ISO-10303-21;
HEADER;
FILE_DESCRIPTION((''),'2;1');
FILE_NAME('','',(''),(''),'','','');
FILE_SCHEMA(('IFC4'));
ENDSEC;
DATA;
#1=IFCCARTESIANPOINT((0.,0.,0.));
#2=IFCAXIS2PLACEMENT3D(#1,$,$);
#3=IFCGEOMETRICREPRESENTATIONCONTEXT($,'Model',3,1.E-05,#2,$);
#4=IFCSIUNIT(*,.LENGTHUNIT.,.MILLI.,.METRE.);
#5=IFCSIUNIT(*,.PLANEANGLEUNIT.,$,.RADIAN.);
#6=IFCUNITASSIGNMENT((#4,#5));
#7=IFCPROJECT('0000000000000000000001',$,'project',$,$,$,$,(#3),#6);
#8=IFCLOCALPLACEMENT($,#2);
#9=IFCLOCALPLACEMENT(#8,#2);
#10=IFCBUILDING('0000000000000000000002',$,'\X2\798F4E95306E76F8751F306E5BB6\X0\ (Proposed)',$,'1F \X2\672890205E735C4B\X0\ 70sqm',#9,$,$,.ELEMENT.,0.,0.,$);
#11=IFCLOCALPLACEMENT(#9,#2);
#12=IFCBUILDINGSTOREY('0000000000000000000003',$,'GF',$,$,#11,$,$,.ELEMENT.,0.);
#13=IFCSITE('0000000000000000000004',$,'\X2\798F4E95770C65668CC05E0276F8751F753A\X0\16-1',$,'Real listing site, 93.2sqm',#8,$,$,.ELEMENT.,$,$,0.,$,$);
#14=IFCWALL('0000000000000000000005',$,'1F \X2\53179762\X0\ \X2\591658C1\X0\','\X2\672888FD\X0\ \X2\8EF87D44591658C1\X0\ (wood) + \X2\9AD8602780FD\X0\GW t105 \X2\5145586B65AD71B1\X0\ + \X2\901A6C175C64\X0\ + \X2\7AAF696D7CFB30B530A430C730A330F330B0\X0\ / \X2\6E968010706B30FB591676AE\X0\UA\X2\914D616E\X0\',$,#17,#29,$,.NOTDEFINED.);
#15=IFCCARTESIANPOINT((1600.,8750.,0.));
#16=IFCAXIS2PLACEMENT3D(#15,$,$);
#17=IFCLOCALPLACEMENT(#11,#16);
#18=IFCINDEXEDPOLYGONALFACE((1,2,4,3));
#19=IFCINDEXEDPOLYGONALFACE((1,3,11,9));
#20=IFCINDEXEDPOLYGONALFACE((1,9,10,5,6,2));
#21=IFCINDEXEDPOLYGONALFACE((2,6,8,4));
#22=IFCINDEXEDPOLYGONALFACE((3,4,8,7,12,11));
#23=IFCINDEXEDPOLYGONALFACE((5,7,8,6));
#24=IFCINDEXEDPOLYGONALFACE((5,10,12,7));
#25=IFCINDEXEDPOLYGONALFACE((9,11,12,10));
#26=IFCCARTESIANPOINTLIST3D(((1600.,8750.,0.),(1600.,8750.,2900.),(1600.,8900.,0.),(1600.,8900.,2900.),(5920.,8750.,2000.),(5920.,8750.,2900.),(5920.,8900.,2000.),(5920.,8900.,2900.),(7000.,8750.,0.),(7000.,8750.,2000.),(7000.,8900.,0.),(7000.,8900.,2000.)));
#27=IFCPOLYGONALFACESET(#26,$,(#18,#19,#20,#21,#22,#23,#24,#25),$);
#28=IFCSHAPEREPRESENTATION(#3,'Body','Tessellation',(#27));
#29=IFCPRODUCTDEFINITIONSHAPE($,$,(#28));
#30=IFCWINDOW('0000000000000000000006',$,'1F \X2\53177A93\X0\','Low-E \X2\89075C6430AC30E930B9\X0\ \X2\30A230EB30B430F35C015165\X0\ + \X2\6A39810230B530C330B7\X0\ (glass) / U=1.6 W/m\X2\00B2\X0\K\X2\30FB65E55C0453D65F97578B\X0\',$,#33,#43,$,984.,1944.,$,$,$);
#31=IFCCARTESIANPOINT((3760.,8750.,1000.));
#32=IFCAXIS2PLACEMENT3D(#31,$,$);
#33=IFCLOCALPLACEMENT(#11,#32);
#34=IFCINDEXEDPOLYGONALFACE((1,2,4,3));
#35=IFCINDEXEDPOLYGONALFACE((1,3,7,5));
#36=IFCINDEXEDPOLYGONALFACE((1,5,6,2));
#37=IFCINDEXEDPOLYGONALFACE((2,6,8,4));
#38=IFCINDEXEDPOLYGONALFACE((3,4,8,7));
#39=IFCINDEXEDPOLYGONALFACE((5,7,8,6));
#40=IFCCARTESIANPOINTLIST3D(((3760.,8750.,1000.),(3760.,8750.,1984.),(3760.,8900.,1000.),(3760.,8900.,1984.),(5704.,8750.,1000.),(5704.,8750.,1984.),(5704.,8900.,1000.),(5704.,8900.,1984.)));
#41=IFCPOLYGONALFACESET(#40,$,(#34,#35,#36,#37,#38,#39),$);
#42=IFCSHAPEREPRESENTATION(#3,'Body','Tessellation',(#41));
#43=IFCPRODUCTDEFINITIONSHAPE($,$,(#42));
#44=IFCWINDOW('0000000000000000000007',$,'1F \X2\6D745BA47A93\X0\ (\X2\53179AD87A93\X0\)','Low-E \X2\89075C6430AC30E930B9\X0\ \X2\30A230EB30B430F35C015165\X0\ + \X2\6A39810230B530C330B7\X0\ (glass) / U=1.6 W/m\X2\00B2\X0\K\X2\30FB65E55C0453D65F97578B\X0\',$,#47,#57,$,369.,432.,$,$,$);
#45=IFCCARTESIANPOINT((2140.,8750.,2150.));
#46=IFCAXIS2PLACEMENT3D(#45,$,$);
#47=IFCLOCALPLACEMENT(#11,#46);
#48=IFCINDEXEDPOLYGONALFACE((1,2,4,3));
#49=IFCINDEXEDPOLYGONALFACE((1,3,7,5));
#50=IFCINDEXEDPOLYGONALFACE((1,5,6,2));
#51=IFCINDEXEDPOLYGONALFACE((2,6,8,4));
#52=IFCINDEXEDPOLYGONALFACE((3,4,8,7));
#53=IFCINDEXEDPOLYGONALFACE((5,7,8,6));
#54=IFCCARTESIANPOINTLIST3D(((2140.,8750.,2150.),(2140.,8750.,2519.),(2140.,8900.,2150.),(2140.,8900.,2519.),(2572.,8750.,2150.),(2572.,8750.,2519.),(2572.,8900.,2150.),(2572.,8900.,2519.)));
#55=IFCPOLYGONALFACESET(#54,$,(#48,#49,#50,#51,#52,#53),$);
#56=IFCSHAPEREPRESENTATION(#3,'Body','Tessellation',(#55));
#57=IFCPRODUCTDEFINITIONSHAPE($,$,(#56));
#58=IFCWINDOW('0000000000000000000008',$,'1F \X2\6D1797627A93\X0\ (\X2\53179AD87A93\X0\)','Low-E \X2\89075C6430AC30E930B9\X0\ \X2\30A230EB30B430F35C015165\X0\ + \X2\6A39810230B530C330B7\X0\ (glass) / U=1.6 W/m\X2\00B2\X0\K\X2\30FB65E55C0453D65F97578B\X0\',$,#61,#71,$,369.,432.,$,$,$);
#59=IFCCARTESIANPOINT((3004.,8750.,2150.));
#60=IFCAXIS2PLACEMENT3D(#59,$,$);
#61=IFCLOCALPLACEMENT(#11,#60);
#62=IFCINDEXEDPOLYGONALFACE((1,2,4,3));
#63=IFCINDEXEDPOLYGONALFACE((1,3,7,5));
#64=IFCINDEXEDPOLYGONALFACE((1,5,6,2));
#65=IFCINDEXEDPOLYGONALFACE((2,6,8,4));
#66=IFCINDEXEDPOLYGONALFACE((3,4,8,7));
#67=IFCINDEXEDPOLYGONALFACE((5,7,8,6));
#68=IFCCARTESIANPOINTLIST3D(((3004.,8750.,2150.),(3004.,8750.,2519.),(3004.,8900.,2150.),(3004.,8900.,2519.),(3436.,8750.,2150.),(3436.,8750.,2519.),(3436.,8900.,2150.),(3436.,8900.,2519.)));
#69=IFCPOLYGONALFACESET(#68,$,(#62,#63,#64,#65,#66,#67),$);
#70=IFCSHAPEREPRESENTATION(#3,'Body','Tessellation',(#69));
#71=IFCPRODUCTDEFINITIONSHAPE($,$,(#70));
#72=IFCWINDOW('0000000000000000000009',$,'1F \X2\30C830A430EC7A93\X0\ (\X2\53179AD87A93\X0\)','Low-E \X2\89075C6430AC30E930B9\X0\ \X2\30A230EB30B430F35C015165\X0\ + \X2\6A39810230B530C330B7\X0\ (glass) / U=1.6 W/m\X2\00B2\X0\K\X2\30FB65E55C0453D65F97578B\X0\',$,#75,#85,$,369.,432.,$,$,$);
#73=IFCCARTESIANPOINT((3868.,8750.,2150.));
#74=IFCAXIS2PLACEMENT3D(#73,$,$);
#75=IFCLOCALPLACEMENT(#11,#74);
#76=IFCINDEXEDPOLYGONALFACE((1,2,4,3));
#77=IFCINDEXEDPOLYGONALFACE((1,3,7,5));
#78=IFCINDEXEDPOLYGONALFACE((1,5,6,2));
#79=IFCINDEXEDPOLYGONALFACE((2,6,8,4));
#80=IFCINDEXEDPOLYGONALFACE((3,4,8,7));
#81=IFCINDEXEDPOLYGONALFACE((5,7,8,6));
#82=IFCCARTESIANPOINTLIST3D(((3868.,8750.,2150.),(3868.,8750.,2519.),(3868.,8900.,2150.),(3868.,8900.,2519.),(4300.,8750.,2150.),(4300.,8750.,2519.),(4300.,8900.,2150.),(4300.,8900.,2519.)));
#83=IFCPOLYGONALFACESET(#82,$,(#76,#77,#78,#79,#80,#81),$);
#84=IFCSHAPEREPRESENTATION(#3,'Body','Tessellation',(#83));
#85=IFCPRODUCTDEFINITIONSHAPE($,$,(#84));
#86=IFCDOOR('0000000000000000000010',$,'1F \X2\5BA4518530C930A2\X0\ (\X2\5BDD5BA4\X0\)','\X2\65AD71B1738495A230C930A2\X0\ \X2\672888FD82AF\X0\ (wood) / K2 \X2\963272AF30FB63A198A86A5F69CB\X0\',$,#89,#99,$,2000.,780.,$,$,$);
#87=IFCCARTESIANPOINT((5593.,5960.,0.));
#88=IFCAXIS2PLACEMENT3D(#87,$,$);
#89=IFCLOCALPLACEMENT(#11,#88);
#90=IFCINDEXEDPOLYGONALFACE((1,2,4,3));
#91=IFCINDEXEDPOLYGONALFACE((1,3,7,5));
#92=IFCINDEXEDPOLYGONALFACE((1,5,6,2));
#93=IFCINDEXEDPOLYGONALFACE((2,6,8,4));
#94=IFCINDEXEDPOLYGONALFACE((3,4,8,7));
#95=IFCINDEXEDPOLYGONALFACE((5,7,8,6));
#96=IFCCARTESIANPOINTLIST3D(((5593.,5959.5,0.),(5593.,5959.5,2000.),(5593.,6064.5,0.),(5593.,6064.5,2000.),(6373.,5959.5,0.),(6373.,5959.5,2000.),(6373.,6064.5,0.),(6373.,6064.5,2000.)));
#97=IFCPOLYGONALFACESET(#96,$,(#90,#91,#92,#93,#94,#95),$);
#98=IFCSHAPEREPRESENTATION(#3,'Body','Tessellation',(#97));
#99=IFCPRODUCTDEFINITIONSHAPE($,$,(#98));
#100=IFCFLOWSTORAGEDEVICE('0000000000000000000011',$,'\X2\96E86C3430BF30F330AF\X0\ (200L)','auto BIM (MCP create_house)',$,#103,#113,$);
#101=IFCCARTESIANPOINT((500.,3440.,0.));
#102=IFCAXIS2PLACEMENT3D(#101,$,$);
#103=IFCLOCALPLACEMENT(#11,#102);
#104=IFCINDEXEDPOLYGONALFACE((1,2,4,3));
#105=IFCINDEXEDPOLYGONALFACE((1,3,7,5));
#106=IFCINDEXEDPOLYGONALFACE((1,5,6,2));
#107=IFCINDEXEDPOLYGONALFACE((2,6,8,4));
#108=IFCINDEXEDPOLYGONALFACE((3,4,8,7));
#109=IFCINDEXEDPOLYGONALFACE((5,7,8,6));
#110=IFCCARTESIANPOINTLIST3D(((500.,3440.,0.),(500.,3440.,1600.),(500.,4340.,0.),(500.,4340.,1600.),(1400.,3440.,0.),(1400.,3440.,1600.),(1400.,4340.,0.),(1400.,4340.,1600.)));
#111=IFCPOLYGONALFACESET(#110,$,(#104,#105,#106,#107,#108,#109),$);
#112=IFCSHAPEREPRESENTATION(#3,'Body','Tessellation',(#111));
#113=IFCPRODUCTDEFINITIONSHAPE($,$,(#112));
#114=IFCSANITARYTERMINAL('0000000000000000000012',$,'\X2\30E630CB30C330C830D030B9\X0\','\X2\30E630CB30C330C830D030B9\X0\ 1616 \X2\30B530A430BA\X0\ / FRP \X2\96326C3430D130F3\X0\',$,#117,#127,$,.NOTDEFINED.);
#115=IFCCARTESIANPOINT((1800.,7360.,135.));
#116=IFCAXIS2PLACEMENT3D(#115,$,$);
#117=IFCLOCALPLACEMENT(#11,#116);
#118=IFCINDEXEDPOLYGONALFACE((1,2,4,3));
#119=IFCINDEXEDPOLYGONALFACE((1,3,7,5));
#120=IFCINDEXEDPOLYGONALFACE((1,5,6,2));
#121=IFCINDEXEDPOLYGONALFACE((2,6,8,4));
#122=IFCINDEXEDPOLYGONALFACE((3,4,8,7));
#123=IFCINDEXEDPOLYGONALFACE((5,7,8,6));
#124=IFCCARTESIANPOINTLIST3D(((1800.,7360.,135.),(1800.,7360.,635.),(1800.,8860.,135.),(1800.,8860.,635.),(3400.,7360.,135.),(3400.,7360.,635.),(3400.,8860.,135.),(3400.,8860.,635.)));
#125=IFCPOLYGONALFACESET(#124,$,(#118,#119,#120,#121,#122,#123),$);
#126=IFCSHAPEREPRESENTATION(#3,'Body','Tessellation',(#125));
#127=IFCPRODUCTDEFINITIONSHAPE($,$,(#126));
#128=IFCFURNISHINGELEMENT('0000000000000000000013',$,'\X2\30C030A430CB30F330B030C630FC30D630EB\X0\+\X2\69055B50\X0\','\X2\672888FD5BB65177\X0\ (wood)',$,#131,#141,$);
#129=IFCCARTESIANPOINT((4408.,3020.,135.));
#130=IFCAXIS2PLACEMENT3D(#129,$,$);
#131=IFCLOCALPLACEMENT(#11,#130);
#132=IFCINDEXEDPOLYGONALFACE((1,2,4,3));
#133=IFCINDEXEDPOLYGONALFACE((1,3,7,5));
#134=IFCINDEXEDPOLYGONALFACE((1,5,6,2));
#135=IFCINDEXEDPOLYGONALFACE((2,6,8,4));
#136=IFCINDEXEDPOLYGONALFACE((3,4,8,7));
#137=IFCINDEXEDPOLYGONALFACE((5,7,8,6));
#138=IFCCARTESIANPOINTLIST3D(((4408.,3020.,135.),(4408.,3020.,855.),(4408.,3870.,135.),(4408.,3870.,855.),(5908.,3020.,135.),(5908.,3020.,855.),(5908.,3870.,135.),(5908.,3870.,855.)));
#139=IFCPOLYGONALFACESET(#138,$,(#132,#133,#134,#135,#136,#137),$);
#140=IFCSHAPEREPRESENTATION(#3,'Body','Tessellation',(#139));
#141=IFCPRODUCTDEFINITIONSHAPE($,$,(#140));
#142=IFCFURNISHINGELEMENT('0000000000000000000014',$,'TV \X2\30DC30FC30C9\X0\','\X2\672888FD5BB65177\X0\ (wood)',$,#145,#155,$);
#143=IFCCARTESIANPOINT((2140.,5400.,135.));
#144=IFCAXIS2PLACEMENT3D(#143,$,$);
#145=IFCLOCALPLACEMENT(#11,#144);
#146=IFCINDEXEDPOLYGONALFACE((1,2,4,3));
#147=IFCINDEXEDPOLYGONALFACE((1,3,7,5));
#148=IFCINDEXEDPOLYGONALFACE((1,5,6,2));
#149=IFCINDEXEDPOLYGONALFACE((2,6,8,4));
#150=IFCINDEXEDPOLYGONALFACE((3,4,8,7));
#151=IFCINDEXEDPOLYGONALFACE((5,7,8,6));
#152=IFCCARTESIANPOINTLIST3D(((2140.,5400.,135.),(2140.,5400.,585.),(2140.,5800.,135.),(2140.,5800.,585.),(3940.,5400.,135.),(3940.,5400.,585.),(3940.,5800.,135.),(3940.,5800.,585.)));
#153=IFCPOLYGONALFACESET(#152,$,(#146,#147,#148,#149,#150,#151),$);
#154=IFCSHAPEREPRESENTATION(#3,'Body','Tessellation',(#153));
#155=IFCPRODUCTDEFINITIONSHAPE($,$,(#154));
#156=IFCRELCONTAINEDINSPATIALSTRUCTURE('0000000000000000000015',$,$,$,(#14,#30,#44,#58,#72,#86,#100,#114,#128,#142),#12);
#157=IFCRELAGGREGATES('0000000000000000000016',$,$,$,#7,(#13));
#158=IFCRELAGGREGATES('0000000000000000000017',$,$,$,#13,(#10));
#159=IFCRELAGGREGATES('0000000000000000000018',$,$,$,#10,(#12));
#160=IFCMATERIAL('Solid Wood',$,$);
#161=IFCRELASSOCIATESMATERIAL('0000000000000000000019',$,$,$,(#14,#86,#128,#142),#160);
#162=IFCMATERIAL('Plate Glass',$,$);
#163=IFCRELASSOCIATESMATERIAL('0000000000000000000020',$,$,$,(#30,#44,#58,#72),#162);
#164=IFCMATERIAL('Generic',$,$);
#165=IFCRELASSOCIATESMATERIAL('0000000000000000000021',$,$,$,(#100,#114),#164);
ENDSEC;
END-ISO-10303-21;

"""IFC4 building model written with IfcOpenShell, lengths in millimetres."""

from ifc_helpers import new_model, si_unit, frame, frame_2d, origin, place, context, project, spatial, rectangle, extrude, material, element, fill, save


model = new_model("IFC4")

# Units and contexts
model_context = context("Model", 3, precision=1e-05, world=origin())
ifc_project = project(units=[si_unit("LENGTHUNIT", "METRE", prefix="MILLI"), si_unit("PLANEANGLEUNIT", "RADIAN")], contexts=[model_context])

# Site, building, storey
site_placement = place(None, origin())
site = spatial("IfcSite", under=ifc_project, at=site_placement, Name="福井県敦賀市相生町16-1", ObjectType="Real listing site, 93.2sqm", CompositionType="ELEMENT", RefElevation=0.0)
building_placement = place(site_placement, origin())
building = spatial("IfcBuilding", under=site, at=building_placement, Name="福井の相生の家 (Proposed)", ObjectType="1F 木造平屋 70sqm", CompositionType="ELEMENT", ElevationOfRefHeight=0.0, ElevationOfTerrain=0.0)
storey_placement = place(building_placement, origin())
storey = spatial("IfcBuildingStorey", under=building, at=storey_placement, Name="GF", CompositionType="ELEMENT", Elevation=0.0)

# Wall, openings, windows
ifc_material_1 = material(Name="Solid Wood")
wall_1_placement = place(storey_placement, frame((1600.0, 8750.0, 0.0)))
wall_1 = element("IfcWall", 1, at=wall_1_placement, inside=storey, material=ifc_material_1, Name="1F 北面 外壁", Description="木製 軸組外壁 (wood) + 高性能GW t105 充填断熱 + 通気層 + 窯業系サイディング / 準耐火・外皮UA配慮", PredefinedType="NOTDEFINED", context=model_context, shape_type="SweptSolid", body=[
    extrude(rectangle(XDim=5400.0, YDim=150.0, at=frame_2d((2700.0, 75.0))), frame((1600.0, 8750.0, 0.0)), (0.0, 0.0, 1.0), 2900.0),
])
opening_1_placement = place(storey_placement, frame((3760.0, 8750.0, 1000.0)))
opening_1 = element("IfcOpeningElement", 2, at=opening_1_placement, cuts=wall_1, PredefinedType="NOTDEFINED", context=model_context, shape_type="SweptSolid", body=[
    extrude(rectangle(XDim=1944.0, YDim=150.0, at=frame_2d((972.0, 75.0))), frame((3760.0, 8750.0, 1000.0)), (0.0, 0.0, 1.0), 984.0),
])
opening_2_placement = place(storey_placement, frame((2140.0, 8750.0, 2150.0)))
opening_2 = element("IfcOpeningElement", 3, at=opening_2_placement, cuts=wall_1, PredefinedType="NOTDEFINED", context=model_context, shape_type="SweptSolid", body=[
    extrude(rectangle(XDim=432.0, YDim=150.0, at=frame_2d((216.0, 75.0))), frame((2140.0, 8750.0, 2150.0)), (0.0, 0.0, 1.0), 369.0),
])
opening_3_placement = place(storey_placement, frame((3004.0, 8750.0, 2150.0)))
opening_3 = element("IfcOpeningElement", 4, at=opening_3_placement, cuts=wall_1, PredefinedType="NOTDEFINED", context=model_context, shape_type="SweptSolid", body=[
    extrude(rectangle(XDim=432.0, YDim=150.0, at=frame_2d((216.0, 75.0))), frame((3004.0, 8750.0, 2150.0)), (0.0, 0.0, 1.0), 369.0),
])
opening_4_placement = place(storey_placement, frame((3868.0, 8750.0, 2150.0)))
opening_4 = element("IfcOpeningElement", 5, at=opening_4_placement, cuts=wall_1, PredefinedType="NOTDEFINED", context=model_context, shape_type="SweptSolid", body=[
    extrude(rectangle(XDim=432.0, YDim=150.0, at=frame_2d((216.0, 75.0))), frame((3868.0, 8750.0, 2150.0)), (0.0, 0.0, 1.0), 369.0),
])
ifc_material_2 = material(Name="Plate Glass")
window_1_placement = place(storey_placement, frame((3760.0, 8750.0, 1000.0)))
window_1 = element("IfcWindow", 6, at=window_1_placement, inside=storey, material=ifc_material_2, Name="1F 北窓", Description="Low-E 複層ガラス アルゴン封入 + 樹脂サッシ (glass) / U=1.6 W/m²K・日射取得型", OverallHeight=984.0, OverallWidth=1944.0, context=model_context, shape_type="SweptSolid", body=[
    extrude(rectangle(XDim=1944.0, YDim=150.0, at=frame_2d((972.0, 75.0))), frame((3760.0, 8750.0, 1000.0)), (0.0, 0.0, 1.0), 984.0),
])
fill(opening_1, window_1)
window_2_placement = place(storey_placement, frame((2140.0, 8750.0, 2150.0)))
window_2 = element("IfcWindow", 7, at=window_2_placement, inside=storey, material=ifc_material_2, Name="1F 浴室窓 (北高窓)", Description="Low-E 複層ガラス アルゴン封入 + 樹脂サッシ (glass) / U=1.6 W/m²K・日射取得型", OverallHeight=369.0, OverallWidth=432.0, context=model_context, shape_type="SweptSolid", body=[
    extrude(rectangle(XDim=432.0, YDim=150.0, at=frame_2d((216.0, 75.0))), frame((2140.0, 8750.0, 2150.0)), (0.0, 0.0, 1.0), 369.0),
])
fill(opening_2, window_2)
window_3_placement = place(storey_placement, frame((3004.0, 8750.0, 2150.0)))
window_3 = element("IfcWindow", 8, at=window_3_placement, inside=storey, material=ifc_material_2, Name="1F 洗面窓 (北高窓)", Description="Low-E 複層ガラス アルゴン封入 + 樹脂サッシ (glass) / U=1.6 W/m²K・日射取得型", OverallHeight=369.0, OverallWidth=432.0, context=model_context, shape_type="SweptSolid", body=[
    extrude(rectangle(XDim=432.0, YDim=150.0, at=frame_2d((216.0, 75.0))), frame((3004.0, 8750.0, 2150.0)), (0.0, 0.0, 1.0), 369.0),
])
fill(opening_3, window_3)
window_4_placement = place(storey_placement, frame((3868.0, 8750.0, 2150.0)))
window_4 = element("IfcWindow", 9, at=window_4_placement, inside=storey, material=ifc_material_2, Name="1F トイレ窓 (北高窓)", Description="Low-E 複層ガラス アルゴン封入 + 樹脂サッシ (glass) / U=1.6 W/m²K・日射取得型", OverallHeight=369.0, OverallWidth=432.0, context=model_context, shape_type="SweptSolid", body=[
    extrude(rectangle(XDim=432.0, YDim=150.0, at=frame_2d((216.0, 75.0))), frame((3868.0, 8750.0, 2150.0)), (0.0, 0.0, 1.0), 369.0),
])
fill(opening_4, window_4)

# Door
door_1_placement = place(storey_placement, frame((5593.0, 5960.0, 0.0)))
element("IfcDoor", 10, at=door_1_placement, inside=storey, material=ifc_material_1, Name="1F 室内ドア (寝室)", Description="断熱玄関ドア 木製芯 (wood) / K2 防犯・採風機構", OverallHeight=2000.0, OverallWidth=780.0, context=model_context, shape_type="SweptSolid", body=[
    extrude(rectangle(XDim=780.0, YDim=105.0, at=frame_2d((390.0, 52.0))), frame((5593.0, 5960.0, 0.0)), (0.0, 0.0, 1.0), 2000.0),
])

# Flow storage device
ifc_material_3 = material(Name="Generic")
flow_storage_device_placement = place(storey_placement, frame((500.0, 3440.0, 0.0)))
element("IfcFlowStorageDevice", 11, at=flow_storage_device_placement, inside=storey, material=ifc_material_3, Name="雨水タンク (200L)", Description="auto BIM (MCP create_house)", context=model_context, shape_type="SweptSolid", body=[
    extrude(rectangle(XDim=900.0, YDim=900.0, at=frame_2d((450.0, 450.0))), frame((500.0, 3440.0, 0.0)), (0.0, 0.0, 1.0), 1600.0),
])

# Sanitary terminal
sanitary_terminal_placement = place(storey_placement, frame((1800.0, 7360.0, 135.0)))
element("IfcSanitaryTerminal", 12, at=sanitary_terminal_placement, inside=storey, material=ifc_material_3, Name="ユニットバス", Description="ユニットバス 1616 サイズ / FRP 防水パン", PredefinedType="NOTDEFINED", context=model_context, shape_type="SweptSolid", body=[
    extrude(rectangle(XDim=1600.0, YDim=1500.0, at=frame_2d((800.0, 750.0))), frame((1800.0, 7360.0, 135.0)), (0.0, 0.0, 1.0), 500.0),
])

# Furnishing elements
furnishing_1_placement = place(storey_placement, frame((4408.0, 3020.0, 135.0)))
element("IfcFurnishingElement", 13, at=furnishing_1_placement, inside=storey, material=ifc_material_1, Name="ダイニングテーブル+椅子", Description="木製家具 (wood)", context=model_context, shape_type="SweptSolid", body=[
    extrude(rectangle(XDim=1500.0, YDim=850.0, at=frame_2d((750.0, 425.0))), frame((4408.0, 3020.0, 135.0)), (0.0, 0.0, 1.0), 720.0),
])
furnishing_2_placement = place(storey_placement, frame((2140.0, 5400.0, 135.0)))
element("IfcFurnishingElement", 14, at=furnishing_2_placement, inside=storey, material=ifc_material_1, Name="TV ボード", Description="木製家具 (wood)", context=model_context, shape_type="SweptSolid", body=[
    extrude(rectangle(XDim=1800.0, YDim=400.0, at=frame_2d((900.0, 200.0))), frame((2140.0, 5400.0, 135.0)), (0.0, 0.0, 1.0), 450.0),
])

save(model, "model.ifc")
